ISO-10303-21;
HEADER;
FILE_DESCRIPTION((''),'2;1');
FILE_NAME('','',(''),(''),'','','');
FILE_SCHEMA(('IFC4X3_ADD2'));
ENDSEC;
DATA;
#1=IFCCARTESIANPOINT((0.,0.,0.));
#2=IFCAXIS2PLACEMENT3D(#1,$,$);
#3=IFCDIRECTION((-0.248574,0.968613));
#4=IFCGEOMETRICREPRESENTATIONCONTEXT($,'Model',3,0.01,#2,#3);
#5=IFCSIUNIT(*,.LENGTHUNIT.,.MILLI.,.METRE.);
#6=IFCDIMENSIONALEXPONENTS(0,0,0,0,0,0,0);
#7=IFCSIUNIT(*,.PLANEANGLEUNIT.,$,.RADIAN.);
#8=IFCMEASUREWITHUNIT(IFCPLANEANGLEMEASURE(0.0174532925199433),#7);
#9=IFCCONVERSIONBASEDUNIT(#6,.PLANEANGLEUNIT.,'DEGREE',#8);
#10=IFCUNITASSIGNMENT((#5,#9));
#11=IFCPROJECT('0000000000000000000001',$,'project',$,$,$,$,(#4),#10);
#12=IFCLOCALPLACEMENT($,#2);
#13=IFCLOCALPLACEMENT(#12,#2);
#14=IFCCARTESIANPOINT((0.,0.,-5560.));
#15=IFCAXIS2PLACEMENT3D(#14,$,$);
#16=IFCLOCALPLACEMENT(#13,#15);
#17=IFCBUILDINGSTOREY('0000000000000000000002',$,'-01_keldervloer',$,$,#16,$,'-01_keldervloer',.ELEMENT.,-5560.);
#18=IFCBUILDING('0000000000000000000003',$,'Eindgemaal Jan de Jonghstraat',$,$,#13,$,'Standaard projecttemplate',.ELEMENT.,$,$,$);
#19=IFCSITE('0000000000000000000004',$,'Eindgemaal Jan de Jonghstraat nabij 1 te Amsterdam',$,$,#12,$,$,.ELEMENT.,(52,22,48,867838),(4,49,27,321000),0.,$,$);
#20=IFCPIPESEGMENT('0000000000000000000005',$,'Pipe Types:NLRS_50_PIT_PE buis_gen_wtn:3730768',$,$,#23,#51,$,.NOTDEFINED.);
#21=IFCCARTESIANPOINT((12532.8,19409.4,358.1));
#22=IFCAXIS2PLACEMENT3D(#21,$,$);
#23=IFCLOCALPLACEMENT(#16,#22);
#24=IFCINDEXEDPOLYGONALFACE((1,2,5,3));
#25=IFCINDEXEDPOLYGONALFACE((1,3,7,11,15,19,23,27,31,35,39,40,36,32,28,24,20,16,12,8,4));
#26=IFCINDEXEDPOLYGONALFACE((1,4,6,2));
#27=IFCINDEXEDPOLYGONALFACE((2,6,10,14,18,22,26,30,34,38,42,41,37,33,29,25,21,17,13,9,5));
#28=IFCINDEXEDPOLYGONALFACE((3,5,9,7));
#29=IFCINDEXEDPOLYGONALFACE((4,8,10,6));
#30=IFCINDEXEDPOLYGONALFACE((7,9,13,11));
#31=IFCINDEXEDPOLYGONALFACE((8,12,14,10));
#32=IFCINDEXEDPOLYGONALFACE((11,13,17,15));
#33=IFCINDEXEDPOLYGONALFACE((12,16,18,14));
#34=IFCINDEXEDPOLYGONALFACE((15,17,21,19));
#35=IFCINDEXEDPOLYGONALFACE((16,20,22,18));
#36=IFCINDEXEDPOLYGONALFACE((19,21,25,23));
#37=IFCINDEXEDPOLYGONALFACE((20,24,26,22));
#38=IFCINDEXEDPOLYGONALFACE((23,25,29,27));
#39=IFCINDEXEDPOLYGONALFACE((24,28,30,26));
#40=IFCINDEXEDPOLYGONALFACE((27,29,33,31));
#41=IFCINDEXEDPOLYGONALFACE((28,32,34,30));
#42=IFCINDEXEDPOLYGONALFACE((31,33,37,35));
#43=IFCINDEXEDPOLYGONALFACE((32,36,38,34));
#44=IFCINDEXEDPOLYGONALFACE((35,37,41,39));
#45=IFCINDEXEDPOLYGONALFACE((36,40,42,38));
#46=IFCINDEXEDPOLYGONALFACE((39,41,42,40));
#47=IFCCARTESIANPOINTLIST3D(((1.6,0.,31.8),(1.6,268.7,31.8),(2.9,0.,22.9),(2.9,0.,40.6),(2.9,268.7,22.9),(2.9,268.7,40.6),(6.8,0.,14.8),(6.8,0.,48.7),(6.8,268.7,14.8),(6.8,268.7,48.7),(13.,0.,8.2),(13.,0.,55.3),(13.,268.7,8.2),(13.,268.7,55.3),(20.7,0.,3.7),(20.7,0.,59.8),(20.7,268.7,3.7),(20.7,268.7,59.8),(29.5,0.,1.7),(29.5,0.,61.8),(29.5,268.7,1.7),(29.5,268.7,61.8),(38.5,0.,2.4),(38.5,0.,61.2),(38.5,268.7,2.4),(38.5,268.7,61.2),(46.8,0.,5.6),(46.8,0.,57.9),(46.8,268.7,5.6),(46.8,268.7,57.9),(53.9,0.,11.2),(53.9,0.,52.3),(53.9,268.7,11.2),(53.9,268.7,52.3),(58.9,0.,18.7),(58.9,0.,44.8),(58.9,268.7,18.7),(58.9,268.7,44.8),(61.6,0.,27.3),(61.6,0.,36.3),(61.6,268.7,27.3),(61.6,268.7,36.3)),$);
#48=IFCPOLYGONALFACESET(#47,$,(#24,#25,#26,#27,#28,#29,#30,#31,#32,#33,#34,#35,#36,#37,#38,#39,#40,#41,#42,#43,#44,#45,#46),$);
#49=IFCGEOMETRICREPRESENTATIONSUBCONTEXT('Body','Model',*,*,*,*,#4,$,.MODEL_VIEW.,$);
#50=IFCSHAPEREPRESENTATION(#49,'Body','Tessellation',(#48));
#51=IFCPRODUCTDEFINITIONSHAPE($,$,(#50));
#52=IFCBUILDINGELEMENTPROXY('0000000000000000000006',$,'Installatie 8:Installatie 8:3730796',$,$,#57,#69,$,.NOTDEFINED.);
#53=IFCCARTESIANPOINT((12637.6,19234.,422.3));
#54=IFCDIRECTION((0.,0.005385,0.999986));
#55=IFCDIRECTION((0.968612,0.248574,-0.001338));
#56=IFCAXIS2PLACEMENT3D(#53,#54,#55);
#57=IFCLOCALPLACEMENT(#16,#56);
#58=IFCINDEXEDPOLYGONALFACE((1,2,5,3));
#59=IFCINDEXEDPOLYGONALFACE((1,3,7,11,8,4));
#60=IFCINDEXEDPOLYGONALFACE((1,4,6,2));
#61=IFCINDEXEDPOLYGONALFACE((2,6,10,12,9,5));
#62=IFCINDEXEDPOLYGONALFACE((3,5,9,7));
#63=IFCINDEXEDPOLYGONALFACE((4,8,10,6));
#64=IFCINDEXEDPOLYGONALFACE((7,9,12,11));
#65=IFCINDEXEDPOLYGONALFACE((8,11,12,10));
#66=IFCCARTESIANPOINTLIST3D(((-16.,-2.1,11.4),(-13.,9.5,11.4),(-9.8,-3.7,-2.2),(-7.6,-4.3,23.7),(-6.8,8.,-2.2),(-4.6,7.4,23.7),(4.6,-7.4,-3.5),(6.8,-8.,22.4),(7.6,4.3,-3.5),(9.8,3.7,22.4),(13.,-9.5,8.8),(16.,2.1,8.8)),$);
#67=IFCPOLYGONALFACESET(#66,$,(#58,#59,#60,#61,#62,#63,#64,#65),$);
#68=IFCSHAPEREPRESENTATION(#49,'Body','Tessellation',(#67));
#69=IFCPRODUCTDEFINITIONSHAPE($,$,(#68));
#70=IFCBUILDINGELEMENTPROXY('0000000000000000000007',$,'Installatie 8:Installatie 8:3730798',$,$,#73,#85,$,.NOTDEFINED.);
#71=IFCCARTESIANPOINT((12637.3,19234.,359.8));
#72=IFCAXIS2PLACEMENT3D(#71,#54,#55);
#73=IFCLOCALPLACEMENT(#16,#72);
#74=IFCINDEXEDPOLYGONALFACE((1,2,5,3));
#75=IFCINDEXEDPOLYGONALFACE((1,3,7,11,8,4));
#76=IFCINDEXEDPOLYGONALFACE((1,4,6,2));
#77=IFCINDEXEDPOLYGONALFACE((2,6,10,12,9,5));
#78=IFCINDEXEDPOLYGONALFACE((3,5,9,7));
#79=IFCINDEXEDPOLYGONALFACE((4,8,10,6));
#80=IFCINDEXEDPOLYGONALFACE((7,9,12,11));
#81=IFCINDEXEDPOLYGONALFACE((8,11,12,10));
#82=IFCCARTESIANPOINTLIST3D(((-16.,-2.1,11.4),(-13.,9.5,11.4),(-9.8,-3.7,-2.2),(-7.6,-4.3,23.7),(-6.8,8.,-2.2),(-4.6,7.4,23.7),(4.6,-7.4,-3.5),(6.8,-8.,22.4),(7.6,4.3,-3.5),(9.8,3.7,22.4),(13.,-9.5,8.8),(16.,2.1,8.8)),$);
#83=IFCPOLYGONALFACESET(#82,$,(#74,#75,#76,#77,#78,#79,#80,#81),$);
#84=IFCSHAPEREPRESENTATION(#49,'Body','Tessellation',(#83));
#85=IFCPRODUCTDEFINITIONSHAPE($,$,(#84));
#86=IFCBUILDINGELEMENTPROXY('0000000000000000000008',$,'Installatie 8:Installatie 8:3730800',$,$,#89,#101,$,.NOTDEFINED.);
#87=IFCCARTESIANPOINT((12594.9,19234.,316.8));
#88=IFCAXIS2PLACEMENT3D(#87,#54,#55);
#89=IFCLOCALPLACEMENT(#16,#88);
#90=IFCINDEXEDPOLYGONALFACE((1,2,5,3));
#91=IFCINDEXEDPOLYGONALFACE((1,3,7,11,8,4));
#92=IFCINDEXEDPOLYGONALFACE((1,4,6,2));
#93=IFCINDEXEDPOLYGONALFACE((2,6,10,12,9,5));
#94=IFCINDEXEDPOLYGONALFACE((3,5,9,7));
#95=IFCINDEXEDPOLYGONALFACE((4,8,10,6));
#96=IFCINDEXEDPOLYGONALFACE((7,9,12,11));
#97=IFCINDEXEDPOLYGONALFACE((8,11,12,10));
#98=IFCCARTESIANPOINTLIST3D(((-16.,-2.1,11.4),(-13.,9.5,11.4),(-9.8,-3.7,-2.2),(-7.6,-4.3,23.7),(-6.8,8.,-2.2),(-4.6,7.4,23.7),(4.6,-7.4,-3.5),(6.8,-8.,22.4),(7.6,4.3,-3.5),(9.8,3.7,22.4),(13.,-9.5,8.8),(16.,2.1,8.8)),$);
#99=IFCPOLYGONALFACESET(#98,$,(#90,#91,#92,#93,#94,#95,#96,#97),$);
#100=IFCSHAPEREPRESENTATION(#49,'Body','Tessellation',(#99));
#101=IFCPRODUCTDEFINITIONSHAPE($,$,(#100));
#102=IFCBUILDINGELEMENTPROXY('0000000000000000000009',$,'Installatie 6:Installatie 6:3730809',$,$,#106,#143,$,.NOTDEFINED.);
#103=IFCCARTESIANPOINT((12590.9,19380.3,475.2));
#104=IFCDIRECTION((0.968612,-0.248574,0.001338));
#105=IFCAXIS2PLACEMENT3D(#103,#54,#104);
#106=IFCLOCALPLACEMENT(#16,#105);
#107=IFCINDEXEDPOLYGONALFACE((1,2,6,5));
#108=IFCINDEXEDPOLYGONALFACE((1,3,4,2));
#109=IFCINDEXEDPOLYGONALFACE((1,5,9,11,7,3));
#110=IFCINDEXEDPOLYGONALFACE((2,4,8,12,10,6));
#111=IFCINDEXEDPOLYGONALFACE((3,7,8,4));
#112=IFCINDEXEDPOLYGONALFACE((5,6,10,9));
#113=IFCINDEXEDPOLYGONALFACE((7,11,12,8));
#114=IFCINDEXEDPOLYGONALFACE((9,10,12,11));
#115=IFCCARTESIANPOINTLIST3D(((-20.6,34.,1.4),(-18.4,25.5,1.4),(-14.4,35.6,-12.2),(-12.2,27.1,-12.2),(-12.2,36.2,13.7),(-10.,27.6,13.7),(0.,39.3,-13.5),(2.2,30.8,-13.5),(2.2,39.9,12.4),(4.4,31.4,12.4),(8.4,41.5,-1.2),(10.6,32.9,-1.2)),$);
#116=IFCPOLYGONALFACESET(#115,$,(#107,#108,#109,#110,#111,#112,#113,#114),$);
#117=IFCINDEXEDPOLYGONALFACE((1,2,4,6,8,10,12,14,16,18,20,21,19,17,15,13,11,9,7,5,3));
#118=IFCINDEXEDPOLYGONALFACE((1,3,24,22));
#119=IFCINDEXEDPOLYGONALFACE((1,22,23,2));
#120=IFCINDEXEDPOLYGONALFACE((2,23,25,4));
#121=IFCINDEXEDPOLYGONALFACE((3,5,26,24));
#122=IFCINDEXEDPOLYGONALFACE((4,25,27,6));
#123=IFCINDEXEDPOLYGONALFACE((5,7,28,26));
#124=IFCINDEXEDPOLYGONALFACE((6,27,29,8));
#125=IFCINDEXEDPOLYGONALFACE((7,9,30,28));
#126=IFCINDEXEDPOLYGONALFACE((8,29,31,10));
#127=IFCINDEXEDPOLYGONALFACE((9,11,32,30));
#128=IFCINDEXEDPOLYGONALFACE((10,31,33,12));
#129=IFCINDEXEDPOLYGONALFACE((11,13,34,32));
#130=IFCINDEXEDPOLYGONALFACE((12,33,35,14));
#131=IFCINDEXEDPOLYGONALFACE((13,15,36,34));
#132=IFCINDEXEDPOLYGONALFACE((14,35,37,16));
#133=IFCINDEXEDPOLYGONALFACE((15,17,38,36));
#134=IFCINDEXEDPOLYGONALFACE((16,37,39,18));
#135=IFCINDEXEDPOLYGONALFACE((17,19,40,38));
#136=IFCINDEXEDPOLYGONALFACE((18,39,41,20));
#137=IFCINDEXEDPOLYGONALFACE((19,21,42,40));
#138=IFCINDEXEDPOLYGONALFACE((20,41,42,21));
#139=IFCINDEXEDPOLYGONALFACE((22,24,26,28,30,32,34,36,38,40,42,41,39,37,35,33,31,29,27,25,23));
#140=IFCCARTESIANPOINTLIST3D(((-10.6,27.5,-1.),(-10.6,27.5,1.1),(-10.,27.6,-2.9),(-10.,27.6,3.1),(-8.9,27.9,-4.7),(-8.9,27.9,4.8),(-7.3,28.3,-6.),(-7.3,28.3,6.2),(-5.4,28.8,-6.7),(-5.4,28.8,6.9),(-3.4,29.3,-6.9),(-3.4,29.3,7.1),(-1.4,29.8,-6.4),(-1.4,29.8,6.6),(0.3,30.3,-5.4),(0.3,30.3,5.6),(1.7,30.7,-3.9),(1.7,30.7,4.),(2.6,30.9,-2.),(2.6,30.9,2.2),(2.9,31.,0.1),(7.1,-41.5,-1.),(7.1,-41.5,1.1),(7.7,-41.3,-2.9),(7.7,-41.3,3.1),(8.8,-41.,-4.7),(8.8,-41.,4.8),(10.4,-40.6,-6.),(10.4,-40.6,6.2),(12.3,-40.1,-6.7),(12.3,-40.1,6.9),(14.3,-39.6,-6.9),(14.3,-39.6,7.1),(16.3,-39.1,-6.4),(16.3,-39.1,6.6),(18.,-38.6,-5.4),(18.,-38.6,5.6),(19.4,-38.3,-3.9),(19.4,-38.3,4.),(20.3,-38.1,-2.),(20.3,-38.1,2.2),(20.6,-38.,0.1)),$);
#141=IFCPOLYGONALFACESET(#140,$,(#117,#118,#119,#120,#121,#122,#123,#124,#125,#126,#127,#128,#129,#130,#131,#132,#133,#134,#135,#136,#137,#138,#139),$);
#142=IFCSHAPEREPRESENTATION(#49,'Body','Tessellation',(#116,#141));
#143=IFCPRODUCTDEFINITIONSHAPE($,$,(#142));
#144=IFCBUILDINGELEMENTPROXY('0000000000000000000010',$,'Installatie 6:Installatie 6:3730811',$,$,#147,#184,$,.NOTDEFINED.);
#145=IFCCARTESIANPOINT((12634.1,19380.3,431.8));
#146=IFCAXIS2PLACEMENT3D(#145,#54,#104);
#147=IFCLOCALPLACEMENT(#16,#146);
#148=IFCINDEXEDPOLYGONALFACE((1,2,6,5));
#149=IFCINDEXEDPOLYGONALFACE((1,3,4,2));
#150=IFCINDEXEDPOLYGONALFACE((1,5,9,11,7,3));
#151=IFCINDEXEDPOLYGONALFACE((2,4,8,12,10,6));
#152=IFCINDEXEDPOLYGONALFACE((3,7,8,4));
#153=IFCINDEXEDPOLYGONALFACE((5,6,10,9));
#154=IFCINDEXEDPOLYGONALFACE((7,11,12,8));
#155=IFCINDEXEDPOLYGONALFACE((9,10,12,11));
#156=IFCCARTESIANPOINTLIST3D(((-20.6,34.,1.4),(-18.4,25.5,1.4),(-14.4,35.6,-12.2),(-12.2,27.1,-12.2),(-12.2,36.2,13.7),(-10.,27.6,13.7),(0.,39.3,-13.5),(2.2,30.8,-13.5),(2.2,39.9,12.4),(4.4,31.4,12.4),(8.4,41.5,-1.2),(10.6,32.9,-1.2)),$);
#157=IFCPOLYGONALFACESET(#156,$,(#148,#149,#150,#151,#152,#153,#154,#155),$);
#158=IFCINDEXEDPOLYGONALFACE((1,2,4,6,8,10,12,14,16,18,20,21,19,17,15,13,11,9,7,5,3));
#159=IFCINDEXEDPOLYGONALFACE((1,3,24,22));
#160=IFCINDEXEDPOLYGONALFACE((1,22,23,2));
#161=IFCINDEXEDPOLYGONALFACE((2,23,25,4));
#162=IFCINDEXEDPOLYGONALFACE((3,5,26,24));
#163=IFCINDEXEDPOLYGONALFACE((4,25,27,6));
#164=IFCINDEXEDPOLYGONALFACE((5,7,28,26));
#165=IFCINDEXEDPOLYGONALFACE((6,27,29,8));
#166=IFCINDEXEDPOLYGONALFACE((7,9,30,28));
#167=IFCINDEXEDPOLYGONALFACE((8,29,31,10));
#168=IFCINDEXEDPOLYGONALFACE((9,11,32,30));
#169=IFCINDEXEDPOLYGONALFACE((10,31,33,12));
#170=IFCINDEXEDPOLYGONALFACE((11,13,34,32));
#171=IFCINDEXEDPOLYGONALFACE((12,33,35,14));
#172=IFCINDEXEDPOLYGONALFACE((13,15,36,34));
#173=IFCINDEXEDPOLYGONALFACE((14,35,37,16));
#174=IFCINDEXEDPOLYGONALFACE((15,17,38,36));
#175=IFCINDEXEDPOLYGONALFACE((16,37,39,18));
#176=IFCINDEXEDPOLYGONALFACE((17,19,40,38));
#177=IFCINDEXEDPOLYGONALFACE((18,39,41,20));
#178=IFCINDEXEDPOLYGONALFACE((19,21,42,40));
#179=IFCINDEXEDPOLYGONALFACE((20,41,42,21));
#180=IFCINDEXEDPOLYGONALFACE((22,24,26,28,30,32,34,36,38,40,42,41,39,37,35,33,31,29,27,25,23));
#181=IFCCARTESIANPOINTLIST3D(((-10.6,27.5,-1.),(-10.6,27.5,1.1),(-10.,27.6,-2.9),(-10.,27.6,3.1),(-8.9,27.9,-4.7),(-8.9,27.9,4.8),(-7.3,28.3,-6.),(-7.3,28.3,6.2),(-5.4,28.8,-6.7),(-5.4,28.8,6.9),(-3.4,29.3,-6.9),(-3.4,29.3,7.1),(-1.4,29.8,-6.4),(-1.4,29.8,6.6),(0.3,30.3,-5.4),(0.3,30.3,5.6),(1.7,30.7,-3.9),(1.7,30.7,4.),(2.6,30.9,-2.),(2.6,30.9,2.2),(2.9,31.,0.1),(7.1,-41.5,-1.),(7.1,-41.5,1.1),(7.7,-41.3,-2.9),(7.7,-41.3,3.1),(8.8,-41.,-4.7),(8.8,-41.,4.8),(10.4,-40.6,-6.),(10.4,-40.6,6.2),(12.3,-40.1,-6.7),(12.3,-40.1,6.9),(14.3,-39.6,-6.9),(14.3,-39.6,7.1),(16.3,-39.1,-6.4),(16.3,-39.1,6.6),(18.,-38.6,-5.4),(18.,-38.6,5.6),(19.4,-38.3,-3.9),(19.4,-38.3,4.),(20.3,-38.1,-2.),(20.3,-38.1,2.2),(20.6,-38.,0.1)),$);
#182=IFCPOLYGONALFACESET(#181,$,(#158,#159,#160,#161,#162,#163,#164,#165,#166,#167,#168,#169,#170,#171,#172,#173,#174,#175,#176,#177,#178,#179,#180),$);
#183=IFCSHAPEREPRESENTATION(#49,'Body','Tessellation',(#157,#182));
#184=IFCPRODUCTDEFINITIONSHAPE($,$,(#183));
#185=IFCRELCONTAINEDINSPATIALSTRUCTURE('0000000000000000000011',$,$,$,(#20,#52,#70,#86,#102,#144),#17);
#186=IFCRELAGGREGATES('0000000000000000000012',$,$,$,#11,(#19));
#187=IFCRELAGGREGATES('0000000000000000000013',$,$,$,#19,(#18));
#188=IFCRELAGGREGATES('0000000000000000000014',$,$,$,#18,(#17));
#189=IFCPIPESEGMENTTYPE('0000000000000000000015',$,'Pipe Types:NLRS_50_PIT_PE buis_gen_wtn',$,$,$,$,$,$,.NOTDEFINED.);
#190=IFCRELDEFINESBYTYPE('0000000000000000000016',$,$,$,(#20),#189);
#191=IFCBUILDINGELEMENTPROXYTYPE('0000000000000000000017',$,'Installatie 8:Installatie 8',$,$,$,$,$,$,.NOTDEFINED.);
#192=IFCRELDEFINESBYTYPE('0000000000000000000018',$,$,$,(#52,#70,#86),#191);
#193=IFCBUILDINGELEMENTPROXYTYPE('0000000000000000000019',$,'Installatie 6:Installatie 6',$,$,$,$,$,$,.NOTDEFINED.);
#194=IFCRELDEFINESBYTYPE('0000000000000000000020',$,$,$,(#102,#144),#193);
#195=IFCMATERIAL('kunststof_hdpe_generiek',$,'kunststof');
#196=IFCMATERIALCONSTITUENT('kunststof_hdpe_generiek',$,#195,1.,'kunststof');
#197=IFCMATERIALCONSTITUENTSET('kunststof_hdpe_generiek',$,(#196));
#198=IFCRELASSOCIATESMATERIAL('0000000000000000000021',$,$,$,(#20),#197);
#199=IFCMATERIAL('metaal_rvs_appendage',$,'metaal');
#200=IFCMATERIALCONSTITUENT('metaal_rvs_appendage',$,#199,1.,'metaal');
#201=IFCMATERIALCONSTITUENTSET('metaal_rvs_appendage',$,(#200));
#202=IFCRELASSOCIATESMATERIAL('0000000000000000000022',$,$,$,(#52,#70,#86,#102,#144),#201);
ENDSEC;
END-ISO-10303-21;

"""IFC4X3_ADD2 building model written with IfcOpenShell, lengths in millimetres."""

from ifc_helpers import new_model, entity, si_unit, converted_unit, direction, frame, frame_2d, origin, origin_2d_with_axis, place, context, subcontext, project, spatial, polyline, circle, outline, extrude, source, transform, mapped, material, constituent, constituent_set, type_object, type_shapes, element, save


model = new_model("IFC4X3_ADD2")

# Units and contexts
model_context = context("Model", 3, precision=0.01, world=origin(), true_north=direction((-0.248574, 0.968613)))
body_context = subcontext(model_context, "Body", "Model", "MODEL_VIEW")
ifc_project = project(units=[si_unit("LENGTHUNIT", "METRE", prefix="MILLI"), converted_unit("PLANEANGLEUNIT", "DEGREE", entity("IfcPlaneAngleMeasure", 0.0174532925199433), si_unit("PLANEANGLEUNIT", "RADIAN"), dimensions=[0, 0, 0, 0, 0, 0, 0])], contexts=[model_context])

# Site, building, storey
site_placement = place(None, origin())
site = spatial("IfcSite", under=ifc_project, at=site_placement, Name="Eindgemaal Jan de Jonghstraat nabij 1 te Amsterdam", CompositionType="ELEMENT", RefLatitude=(52, 22, 48, 867838), RefLongitude=(4, 49, 27, 321000), RefElevation=0.0)
building_placement = place(site_placement, origin())
building = spatial("IfcBuilding", under=site, at=building_placement, Name="Eindgemaal Jan de Jonghstraat", LongName="Standaard projecttemplate", CompositionType="ELEMENT")
storey_placement = place(building_placement, frame((0.0, 0.0, -5560.0)))
storey = spatial("IfcBuildingStorey", under=building, at=storey_placement, Name="-01_keldervloer", LongName="-01_keldervloer", CompositionType="ELEMENT", Elevation=-5560.0)

# Pipe segment
ifc_material_1 = material(Name="kunststof_hdpe_generiek", Category="kunststof")
ifc_constituent_1 = constituent(ifc_material_1, Name="kunststof_hdpe_generiek", Category="kunststof", fraction=1.0)
ifc_constituent_set_1 = constituent_set(constituents=[ifc_constituent_1], Name="kunststof_hdpe_generiek")
pipe_segment_type_1 = type_object("IfcPipeSegmentType", Name="Pipe Types:NLRS_50_PIT_PE buis_gen_wtn", PredefinedType="NOTDEFINED")
pipe_segment_1_placement = place(storey_placement, frame((12532.8, 19409.4, 358.1)))
element("IfcPipeSegment", 1, at=pipe_segment_1_placement, inside=storey, type_object=pipe_segment_type_1, material=ifc_constituent_set_1, Name="Pipe Types:NLRS_50_PIT_PE buis_gen_wtn:3730768", PredefinedType="NOTDEFINED", context=body_context, shape_type="SweptSolid", body=[
    extrude(circle(Radius=30.2, at=origin_2d_with_axis()), frame((31.8, 0.0, 31.8), z_axis=(0.0, 1.0, 0.0), x_axis=(-1.0, 0.0, 0.0)), (0.0, 0.0, 1.0), 268.7),
])

# Building element proxies
ifc_material_2 = material(Name="metaal_rvs_appendage", Category="metaal")
ifc_constituent_2 = constituent(ifc_material_2, Name="metaal_rvs_appendage", Category="metaal", fraction=1.0)
ifc_constituent_set_2 = constituent_set(constituents=[ifc_constituent_2], Name="metaal_rvs_appendage")
building_element_proxy_type_1 = type_object("IfcBuildingElementProxyType", Name="Installatie 8:Installatie 8", PredefinedType="NOTDEFINED")
shared_shape_1 = source(origin(), body_context, "Body", "SweptSolid", [
    extrude(outline(polyline([(-7.5, -13.0), (7.5, -13.0), (15.0, 0.0), (7.5, 13.0), (-7.5, 13.0), (-15.0, 0.0), (-7.5, -13.0)])), frame((-1.5, -5.8, 10.1), z_axis=(0.248574, 0.968613, 0.0), x_axis=(-0.555573, 0.142576, -0.819152)), (0.0, 0.0, 1.0), 12.0),
])
type_shapes(building_element_proxy_type_1, [shared_shape_1])
for number, where, z_axis, x_axis, name in (
    (2, (12637.6, 19234.0, 422.3), (0.0, 0.005385, 0.999986), (0.968612, 0.248574, -0.001338), "Installatie 8:Installatie 8:3730796"),
    (3, (12637.3, 19234.0, 359.8), (0.0, 0.005385, 0.999986), (0.968612, 0.248574, -0.001338), "Installatie 8:Installatie 8:3730798"),
    (4, (12594.9, 19234.0, 316.8), (0.0, 0.005385, 0.999986), (0.968612, 0.248574, -0.001338), "Installatie 8:Installatie 8:3730800"),
):
    element("IfcBuildingElementProxy", number, at=place(storey_placement, frame(where, z_axis=z_axis, x_axis=x_axis)), inside=storey, type_object=building_element_proxy_type_1, material=ifc_constituent_set_2, Name=name, PredefinedType="NOTDEFINED", context=body_context, shape_type="MappedRepresentation", body=[
        mapped(shared_shape_1, transform((0.0, 0.0, 0.0), scale=1.0)),
    ])
building_element_proxy_type_2 = type_object("IfcBuildingElementProxyType", Name="Installatie 6:Installatie 6", PredefinedType="NOTDEFINED")
shared_shape_2 = source(origin(), body_context, "Body", "SweptSolid", [
    extrude(outline(polyline([(-7.5, -13.0), (7.5, -13.0), (15.0, 0.0), (7.5, 13.0), (-7.5, 13.0), (-15.0, 0.0), (-7.5, -13.0)])), frame((-3.9, 29.2, 0.1), z_axis=(-0.248574, 0.968613, 0.0), x_axis=(-0.555573, -0.142576, -0.819152)), (0.0, 0.0, 1.0), 8.8),
    extrude(circle(Radius=7.0, at=frame_2d((0.0, 0.0), x_axis=(1.0, 0.0))), frame((-3.9, 29.2, 0.1), z_axis=(0.248574, -0.968613, 0.0), x_axis=(0.968613, 0.248574, 0.0)), (0.0, 0.0, 1.0), 71.2),
])
type_shapes(building_element_proxy_type_2, [shared_shape_2])
for number, where, z_axis, x_axis, name in (
    (5, (12590.9, 19380.3, 475.2), (0.0, 0.005385, 0.999986), (0.968612, -0.248574, 0.001338), "Installatie 6:Installatie 6:3730809"),
    (6, (12634.1, 19380.3, 431.8), (0.0, 0.005385, 0.999986), (0.968612, -0.248574, 0.001338), "Installatie 6:Installatie 6:3730811"),
):
    element("IfcBuildingElementProxy", number, at=place(storey_placement, frame(where, z_axis=z_axis, x_axis=x_axis)), inside=storey, type_object=building_element_proxy_type_2, material=ifc_constituent_set_2, Name=name, PredefinedType="NOTDEFINED", context=body_context, shape_type="MappedRepresentation", body=[
        mapped(shared_shape_2, transform((0.0, 0.0, 0.0), scale=1.0)),
    ])

save(model, "model.ifc")
